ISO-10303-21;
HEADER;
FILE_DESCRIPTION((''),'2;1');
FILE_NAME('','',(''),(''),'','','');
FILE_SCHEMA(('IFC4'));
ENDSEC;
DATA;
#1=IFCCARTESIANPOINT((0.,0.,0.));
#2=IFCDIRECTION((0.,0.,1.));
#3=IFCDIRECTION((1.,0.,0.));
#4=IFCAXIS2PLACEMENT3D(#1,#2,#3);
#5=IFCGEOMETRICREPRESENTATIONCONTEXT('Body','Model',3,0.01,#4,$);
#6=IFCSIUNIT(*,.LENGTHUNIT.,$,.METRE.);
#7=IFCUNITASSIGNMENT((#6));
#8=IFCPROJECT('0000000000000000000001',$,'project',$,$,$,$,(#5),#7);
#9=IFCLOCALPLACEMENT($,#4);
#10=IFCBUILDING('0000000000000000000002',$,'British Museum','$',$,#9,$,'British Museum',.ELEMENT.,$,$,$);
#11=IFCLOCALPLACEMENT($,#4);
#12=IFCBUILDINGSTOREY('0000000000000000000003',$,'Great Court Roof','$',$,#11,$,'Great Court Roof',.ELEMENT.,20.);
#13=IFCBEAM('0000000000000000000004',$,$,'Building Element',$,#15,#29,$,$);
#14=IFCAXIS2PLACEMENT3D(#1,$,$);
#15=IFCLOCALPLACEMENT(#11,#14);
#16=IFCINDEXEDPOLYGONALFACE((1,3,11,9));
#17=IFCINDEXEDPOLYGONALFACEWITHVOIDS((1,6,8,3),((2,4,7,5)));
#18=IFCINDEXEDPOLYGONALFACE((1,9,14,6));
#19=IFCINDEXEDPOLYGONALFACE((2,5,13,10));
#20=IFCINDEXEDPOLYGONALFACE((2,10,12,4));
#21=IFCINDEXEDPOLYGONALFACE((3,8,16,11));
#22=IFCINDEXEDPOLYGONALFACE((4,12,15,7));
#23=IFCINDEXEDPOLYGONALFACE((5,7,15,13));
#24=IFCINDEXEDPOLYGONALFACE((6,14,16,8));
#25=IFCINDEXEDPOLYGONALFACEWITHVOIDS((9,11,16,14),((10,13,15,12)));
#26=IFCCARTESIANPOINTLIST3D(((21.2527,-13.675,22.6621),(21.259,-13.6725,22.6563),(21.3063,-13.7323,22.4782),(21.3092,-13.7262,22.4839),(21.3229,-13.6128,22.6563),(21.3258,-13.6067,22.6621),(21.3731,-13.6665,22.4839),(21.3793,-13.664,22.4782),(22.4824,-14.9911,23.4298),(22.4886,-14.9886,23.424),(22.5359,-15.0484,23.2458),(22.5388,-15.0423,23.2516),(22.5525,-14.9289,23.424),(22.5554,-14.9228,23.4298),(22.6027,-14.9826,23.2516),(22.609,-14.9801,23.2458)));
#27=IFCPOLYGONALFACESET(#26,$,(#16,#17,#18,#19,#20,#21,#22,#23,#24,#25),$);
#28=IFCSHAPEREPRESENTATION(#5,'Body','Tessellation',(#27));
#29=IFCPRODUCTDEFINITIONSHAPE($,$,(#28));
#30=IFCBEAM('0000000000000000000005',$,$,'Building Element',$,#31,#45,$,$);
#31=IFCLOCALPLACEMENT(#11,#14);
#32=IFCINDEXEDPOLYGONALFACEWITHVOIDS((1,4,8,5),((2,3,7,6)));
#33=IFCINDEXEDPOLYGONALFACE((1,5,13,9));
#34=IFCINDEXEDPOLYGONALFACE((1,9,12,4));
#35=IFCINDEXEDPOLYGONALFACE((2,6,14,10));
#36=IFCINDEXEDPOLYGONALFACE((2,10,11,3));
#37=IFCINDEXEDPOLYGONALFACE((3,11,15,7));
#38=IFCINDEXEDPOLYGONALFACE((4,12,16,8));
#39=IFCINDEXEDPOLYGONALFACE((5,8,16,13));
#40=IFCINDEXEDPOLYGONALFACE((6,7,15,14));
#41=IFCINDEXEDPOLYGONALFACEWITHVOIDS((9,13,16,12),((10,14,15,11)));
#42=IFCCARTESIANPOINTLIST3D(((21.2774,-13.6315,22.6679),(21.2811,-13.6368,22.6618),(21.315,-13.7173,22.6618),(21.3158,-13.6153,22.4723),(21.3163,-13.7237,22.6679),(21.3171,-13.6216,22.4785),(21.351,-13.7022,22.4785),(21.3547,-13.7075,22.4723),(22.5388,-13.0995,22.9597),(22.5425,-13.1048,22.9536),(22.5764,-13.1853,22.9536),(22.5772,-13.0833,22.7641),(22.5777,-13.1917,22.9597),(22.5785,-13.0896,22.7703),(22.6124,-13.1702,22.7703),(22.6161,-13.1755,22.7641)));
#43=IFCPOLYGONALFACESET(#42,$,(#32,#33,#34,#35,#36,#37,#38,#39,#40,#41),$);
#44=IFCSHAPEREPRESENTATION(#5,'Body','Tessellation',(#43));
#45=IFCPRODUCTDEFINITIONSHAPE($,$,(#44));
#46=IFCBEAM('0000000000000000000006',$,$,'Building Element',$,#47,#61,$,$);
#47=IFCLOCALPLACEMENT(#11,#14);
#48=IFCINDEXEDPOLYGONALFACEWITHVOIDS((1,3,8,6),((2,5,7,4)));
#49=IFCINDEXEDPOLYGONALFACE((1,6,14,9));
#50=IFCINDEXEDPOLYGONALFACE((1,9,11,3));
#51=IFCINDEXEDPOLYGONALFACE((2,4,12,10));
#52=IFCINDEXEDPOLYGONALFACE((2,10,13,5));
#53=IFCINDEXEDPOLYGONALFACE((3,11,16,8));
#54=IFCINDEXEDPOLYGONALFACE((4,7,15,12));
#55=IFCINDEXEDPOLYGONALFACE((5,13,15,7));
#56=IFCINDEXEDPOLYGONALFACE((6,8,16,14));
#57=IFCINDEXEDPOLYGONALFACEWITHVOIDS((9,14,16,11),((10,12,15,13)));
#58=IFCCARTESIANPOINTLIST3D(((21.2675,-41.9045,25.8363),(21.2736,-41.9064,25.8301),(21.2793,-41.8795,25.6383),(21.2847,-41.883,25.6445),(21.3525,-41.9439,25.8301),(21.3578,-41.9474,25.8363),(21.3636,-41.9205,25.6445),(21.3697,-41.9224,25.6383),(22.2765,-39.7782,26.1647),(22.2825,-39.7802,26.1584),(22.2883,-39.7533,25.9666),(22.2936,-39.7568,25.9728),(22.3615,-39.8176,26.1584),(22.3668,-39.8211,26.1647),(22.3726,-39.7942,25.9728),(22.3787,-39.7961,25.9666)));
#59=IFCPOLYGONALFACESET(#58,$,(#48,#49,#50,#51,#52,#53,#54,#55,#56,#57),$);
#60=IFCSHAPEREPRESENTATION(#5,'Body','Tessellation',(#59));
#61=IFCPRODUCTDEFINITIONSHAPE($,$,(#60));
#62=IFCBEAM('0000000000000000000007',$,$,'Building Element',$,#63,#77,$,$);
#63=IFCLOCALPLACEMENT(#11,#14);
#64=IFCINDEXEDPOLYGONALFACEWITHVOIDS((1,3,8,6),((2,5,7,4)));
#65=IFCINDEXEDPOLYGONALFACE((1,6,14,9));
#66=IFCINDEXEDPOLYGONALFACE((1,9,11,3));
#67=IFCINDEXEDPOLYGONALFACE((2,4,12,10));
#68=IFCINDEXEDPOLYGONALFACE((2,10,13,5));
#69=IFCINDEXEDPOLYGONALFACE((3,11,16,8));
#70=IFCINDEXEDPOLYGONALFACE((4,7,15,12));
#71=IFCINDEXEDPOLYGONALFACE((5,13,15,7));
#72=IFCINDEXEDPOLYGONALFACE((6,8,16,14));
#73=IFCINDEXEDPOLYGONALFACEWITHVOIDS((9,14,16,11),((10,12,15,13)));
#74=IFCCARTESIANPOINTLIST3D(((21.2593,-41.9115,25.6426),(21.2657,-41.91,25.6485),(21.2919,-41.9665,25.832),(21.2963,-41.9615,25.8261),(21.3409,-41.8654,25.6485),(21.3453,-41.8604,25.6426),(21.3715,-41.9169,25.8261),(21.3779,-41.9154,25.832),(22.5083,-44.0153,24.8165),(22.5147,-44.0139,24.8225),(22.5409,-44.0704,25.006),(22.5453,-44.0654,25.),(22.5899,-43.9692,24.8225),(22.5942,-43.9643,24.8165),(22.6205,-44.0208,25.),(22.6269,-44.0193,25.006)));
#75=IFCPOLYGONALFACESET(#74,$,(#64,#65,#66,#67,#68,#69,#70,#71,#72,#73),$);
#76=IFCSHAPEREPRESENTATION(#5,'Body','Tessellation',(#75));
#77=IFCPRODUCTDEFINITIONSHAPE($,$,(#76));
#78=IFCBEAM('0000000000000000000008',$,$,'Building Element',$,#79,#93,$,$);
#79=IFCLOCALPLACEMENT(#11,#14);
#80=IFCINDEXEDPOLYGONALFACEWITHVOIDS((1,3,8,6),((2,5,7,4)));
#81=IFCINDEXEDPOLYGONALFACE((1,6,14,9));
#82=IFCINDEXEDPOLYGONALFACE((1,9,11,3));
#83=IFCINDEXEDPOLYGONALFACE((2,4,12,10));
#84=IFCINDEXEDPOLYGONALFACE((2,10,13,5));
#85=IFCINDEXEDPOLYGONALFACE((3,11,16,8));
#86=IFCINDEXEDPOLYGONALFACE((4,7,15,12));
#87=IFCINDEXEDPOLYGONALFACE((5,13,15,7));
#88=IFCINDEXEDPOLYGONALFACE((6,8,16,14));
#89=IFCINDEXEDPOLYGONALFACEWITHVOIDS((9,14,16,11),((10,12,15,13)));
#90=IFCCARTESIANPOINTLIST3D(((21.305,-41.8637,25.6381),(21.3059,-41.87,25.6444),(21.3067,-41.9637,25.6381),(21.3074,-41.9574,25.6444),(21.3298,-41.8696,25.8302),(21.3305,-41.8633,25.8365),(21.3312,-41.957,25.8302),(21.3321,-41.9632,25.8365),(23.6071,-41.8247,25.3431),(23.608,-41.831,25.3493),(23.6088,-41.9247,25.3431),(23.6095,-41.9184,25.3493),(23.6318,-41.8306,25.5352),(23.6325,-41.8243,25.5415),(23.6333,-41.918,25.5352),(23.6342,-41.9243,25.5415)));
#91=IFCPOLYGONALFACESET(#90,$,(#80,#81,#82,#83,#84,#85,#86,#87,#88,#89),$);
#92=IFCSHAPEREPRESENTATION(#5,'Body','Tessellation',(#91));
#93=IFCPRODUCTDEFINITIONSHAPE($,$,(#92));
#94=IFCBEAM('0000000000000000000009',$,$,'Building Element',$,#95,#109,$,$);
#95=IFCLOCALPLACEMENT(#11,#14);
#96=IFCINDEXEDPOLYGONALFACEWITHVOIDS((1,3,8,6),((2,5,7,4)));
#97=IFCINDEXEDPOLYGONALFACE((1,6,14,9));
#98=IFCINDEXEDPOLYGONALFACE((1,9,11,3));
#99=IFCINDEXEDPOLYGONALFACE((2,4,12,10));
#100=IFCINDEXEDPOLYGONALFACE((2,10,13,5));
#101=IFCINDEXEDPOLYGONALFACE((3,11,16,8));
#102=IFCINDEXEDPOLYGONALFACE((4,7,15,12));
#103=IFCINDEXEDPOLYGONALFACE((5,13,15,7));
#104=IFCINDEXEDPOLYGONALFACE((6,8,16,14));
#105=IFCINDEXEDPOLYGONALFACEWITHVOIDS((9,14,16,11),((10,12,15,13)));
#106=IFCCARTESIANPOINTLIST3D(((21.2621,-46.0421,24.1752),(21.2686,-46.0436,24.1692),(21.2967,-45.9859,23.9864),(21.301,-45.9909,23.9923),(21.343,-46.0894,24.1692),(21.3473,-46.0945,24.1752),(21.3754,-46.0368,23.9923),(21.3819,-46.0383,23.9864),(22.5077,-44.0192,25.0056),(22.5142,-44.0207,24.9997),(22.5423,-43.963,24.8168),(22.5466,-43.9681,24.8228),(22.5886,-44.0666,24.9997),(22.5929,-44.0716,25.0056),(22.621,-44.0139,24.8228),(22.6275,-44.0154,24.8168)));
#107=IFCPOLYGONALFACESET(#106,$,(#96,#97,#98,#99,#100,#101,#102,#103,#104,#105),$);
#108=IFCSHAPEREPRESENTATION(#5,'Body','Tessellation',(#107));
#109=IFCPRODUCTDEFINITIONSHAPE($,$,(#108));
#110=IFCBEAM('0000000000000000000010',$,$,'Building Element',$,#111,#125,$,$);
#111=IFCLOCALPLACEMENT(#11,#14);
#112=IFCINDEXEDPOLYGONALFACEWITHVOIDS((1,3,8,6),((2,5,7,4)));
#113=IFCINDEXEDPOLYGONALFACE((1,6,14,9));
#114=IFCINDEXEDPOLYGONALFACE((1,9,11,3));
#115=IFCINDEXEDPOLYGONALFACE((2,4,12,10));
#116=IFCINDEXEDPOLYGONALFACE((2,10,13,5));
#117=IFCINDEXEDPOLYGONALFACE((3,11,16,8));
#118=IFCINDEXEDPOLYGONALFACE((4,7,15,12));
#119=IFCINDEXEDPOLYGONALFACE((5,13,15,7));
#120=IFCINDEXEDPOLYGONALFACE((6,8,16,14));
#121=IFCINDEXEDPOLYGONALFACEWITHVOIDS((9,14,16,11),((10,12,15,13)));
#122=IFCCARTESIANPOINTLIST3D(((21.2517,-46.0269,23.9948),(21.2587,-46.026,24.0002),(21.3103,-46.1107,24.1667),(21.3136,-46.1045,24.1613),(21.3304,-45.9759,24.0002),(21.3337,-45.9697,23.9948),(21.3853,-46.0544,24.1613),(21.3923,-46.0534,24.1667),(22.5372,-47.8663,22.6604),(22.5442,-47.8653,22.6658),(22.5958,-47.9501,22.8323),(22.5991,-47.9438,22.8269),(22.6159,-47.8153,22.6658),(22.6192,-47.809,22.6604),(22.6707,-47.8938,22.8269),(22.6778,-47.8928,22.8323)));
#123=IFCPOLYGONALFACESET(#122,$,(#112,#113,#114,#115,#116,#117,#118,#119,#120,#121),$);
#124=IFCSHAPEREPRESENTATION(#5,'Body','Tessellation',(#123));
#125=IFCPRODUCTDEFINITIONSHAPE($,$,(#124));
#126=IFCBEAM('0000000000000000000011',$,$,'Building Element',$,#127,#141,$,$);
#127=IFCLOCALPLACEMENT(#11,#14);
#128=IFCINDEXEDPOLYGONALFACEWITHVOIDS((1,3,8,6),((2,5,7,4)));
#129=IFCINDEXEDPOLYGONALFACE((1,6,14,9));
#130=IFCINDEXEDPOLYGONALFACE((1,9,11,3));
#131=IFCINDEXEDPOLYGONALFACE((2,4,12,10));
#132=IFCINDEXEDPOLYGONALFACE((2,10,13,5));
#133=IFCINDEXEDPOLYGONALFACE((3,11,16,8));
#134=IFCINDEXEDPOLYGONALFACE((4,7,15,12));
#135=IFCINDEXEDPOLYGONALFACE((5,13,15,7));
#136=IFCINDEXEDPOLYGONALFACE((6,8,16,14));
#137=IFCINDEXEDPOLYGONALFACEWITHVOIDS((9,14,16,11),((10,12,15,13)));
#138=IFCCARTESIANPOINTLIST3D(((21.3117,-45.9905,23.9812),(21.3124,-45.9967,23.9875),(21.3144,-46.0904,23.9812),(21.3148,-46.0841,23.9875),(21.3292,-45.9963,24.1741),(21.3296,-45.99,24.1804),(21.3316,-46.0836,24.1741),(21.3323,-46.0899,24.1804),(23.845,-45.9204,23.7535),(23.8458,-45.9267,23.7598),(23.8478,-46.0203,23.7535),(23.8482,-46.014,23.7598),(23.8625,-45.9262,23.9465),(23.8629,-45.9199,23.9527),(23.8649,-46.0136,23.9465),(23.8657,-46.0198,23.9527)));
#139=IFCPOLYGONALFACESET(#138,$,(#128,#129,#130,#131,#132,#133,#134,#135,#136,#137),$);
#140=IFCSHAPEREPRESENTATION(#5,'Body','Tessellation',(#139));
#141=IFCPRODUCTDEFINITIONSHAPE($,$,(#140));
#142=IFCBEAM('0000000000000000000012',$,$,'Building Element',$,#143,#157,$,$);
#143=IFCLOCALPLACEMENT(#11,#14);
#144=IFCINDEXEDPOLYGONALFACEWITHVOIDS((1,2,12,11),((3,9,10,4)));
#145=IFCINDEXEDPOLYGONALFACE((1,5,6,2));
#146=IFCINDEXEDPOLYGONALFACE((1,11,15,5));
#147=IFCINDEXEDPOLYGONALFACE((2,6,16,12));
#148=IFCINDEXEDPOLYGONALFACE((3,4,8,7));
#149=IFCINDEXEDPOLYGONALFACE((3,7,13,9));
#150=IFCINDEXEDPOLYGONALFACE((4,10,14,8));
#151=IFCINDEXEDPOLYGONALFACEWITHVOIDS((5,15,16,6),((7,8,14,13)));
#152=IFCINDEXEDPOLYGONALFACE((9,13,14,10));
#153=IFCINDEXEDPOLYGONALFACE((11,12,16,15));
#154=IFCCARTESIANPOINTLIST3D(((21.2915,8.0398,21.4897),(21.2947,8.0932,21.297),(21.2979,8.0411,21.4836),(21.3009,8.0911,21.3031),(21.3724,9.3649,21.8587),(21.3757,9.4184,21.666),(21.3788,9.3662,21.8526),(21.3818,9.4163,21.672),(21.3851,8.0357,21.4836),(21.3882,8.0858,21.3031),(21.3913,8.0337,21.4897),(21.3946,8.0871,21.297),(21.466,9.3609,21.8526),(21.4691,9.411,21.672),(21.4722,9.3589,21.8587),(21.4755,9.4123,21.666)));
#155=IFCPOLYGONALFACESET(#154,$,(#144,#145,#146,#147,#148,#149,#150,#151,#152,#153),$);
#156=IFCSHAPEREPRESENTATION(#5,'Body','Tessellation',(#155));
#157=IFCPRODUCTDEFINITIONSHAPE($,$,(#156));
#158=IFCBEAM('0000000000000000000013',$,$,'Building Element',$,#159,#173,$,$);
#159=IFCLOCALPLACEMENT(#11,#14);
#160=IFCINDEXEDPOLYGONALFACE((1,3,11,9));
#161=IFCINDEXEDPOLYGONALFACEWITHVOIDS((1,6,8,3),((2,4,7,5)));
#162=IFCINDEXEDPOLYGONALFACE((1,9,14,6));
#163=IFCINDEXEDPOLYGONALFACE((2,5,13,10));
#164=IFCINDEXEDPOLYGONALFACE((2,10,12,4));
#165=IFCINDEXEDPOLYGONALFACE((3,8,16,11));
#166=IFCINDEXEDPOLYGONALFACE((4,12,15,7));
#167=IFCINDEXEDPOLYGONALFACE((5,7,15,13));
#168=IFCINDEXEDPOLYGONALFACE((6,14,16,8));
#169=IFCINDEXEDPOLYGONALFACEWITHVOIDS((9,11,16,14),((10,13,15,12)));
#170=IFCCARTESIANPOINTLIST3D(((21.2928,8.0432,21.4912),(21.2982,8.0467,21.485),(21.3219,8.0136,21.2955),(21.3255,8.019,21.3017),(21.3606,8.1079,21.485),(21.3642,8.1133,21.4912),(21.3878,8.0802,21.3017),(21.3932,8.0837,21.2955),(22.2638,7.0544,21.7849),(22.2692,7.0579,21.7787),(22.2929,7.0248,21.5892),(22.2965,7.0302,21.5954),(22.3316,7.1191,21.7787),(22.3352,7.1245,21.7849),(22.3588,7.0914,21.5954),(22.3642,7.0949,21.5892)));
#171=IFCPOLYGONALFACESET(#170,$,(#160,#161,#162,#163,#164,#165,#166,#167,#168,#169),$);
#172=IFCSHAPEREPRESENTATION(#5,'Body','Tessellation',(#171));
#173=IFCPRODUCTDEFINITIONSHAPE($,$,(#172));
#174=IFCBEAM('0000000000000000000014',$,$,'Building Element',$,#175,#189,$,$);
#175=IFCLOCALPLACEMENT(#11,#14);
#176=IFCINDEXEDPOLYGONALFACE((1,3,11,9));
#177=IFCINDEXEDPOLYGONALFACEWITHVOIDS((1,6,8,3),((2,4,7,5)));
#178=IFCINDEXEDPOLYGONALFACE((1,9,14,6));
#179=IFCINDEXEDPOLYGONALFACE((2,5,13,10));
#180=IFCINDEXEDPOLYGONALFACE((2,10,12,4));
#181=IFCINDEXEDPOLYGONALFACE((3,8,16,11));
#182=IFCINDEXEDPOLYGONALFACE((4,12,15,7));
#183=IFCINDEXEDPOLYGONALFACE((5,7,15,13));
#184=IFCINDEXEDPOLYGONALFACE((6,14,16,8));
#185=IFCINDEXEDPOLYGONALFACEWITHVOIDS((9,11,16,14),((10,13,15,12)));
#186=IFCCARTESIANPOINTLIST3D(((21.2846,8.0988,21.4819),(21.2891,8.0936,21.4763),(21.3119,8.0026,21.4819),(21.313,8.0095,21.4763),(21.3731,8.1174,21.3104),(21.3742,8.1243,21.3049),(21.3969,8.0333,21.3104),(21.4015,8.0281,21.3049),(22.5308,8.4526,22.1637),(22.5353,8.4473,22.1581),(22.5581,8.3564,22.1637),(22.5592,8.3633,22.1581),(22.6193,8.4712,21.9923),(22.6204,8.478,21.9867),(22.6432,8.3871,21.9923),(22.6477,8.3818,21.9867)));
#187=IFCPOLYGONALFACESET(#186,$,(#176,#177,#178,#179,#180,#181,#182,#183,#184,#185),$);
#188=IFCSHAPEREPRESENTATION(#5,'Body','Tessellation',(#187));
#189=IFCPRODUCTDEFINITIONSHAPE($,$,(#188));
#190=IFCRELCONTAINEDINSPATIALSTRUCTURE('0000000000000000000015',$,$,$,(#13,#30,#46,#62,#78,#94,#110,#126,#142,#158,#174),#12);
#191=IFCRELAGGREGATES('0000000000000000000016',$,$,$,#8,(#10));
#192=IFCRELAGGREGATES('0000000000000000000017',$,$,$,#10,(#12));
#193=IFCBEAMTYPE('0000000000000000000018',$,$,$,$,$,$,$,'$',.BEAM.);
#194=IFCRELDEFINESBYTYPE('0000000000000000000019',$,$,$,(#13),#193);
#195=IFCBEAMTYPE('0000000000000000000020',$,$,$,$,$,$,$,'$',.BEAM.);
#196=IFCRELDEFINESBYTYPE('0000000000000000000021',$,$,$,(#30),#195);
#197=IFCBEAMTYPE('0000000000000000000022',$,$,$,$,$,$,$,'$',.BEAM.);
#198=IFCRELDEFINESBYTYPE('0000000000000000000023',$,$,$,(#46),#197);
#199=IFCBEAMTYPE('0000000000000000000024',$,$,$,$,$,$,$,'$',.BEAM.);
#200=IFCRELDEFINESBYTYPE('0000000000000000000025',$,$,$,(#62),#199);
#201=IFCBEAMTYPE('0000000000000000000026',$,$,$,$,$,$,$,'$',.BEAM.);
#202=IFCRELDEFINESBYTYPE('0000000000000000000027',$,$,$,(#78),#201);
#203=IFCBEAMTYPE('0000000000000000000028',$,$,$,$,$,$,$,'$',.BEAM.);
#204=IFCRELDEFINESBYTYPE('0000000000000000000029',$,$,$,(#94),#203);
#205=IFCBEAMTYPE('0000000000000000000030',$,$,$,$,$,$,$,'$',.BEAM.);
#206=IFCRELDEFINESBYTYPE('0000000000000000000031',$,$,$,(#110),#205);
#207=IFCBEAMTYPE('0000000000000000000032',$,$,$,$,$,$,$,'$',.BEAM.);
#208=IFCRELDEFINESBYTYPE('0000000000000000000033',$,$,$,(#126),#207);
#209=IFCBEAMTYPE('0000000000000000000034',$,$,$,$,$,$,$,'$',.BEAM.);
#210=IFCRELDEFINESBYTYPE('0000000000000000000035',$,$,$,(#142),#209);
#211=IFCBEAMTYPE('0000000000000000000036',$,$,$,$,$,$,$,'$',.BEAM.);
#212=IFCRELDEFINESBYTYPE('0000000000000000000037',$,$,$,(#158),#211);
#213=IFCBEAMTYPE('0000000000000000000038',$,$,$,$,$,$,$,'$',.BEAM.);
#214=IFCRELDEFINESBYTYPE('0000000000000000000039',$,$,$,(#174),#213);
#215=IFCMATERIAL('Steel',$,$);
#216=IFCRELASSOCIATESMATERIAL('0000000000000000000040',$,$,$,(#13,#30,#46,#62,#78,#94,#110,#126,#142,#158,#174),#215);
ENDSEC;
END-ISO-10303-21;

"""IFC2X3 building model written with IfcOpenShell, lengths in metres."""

from ifc_helpers import new_model, si_unit, frame, origin_with_axes, origin_2d, place, context, project, spatial, hollow_rectangle, extrude, material, type_object, element, save


model = new_model("IFC2X3")

# Units and contexts
model_context = context("Model", 3, precision=0.01, world=origin_with_axes(), identifier="Body")
ifc_project = project(units=[si_unit("LENGTHUNIT", "METRE")], contexts=[model_context])

# Building, storey
building_placement = place(None, origin_with_axes())
building = spatial("IfcBuilding", under=ifc_project, at=building_placement, Name="British Museum", Description="$", LongName="British Museum", CompositionType="ELEMENT")
storey_placement = place(None, origin_with_axes())
storey = spatial("IfcBuildingStorey", under=building, at=storey_placement, Name="Great Court Roof", Description="$", LongName="Great Court Roof", CompositionType="ELEMENT", Elevation=20.0)

# Beams
ifc_material = material(Name="Steel")
beam_type_1 = type_object("IfcBeamType", ElementType="$", PredefinedType="BEAM")
beam_1_placement = place(None, origin_with_axes())
element("IfcBeam", 1, at=beam_1_placement, inside=storey, type_object=beam_type_1, material=ifc_material, Description="Building Element", context=model_context, shape_type="SweptSolid", body=[
    extrude(hollow_rectangle(XDim=0.1, YDim=0.2, WallThickness=0.0063, InnerFilletRadius=0.0, OuterFilletRadius=0.0, at=origin_2d()), frame((21.316, -13.6695, 22.5701), z_axis=(0.628033, -0.672197, 0.392079), x_axis=(0.730703, 0.682695, 0.0)), (0.0, 0.0, 1.0), 1.9579),
])
beam_type_2 = type_object("IfcBeamType", ElementType="$", PredefinedType="BEAM")
beam_2_placement = place(None, origin_with_axes())
element("IfcBeam", 2, at=beam_2_placement, inside=storey, type_object=beam_type_2, material=ifc_material, Description="Building Element", context=model_context, shape_type="SweptSolid", body=[
    extrude(hollow_rectangle(XDim=0.1, YDim=0.2, WallThickness=0.0063, InnerFilletRadius=0.0, OuterFilletRadius=0.0, at=origin_2d()), frame((21.316, -13.6695, 22.5701), z_axis=(0.90116, 0.380072, 0.208459), x_axis=(-0.388609, 0.921403, 0.0)), (0.0, 0.0, 1.0), 1.3998),
])
beam_type_3 = type_object("IfcBeamType", ElementType="$", PredefinedType="BEAM")
beam_3_placement = place(None, origin_with_axes())
element("IfcBeam", 3, at=beam_3_placement, inside=storey, type_object=beam_type_3, material=ifc_material, Description="Building Element", context=model_context, shape_type="SweptSolid", body=[
    extrude(hollow_rectangle(XDim=0.1, YDim=0.2, WallThickness=0.0063, InnerFilletRadius=0.0, OuterFilletRadius=0.0, at=origin_2d()), frame((21.3186, -41.9135, 25.7373), z_axis=(0.424592, 0.894779, 0.138174), x_axis=(-0.903445, 0.428704, 0.0)), (0.0, 0.0, 1.0), 2.3763),
])
beam_type_4 = type_object("IfcBeamType", ElementType="$", PredefinedType="BEAM")
beam_4_placement = place(None, origin_with_axes())
element("IfcBeam", 4, at=beam_4_placement, inside=storey, type_object=beam_type_4, material=ifc_material, Description="Building Element", context=model_context, shape_type="SweptSolid", body=[
    extrude(hollow_rectangle(XDim=0.1, YDim=0.2, WallThickness=0.0063, InnerFilletRadius=0.0, OuterFilletRadius=0.0, at=origin_2d()), frame((21.3186, -41.9135, 25.7373), z_axis=(0.483662, -0.814704, -0.319888), x_axis=(0.859886, 0.510486, 0.0)), (0.0, 0.0, 1.0), 2.5824),
])
beam_type_5 = type_object("IfcBeamType", ElementType="$", PredefinedType="BEAM")
beam_5_placement = place(None, origin_with_axes())
element("IfcBeam", 5, at=beam_5_placement, inside=storey, type_object=beam_type_5, material=ifc_material, Description="Building Element", context=model_context, shape_type="SweptSolid", body=[
    extrude(hollow_rectangle(XDim=0.1, YDim=0.2, WallThickness=0.0063, InnerFilletRadius=0.0, OuterFilletRadius=0.0, at=origin_2d()), frame((21.3186, -41.9135, 25.7373), z_axis=(0.991748, 0.016784, -0.127103), x_axis=(-0.016921, 0.999857, 0.0)), (0.0, 0.0, 1.0), 2.3212),
])
beam_type_6 = type_object("IfcBeamType", ElementType="$", PredefinedType="BEAM")
beam_6_placement = place(None, origin_with_axes())
element("IfcBeam", 6, at=beam_6_placement, inside=storey, type_object=beam_type_6, material=ifc_material, Description="Building Element", context=model_context, shape_type="SweptSolid", body=[
    extrude(hollow_rectangle(XDim=0.1, YDim=0.2, WallThickness=0.0063, InnerFilletRadius=0.0, OuterFilletRadius=0.0, at=origin_2d()), frame((21.322, -46.0402, 24.0808), z_axis=(0.494955, 0.803819, 0.329993), x_axis=(-0.851518, 0.524326, 0.0)), (0.0, 0.0, 1.0), 2.5166),
])
beam_type_7 = type_object("IfcBeamType", ElementType="$", PredefinedType="BEAM")
beam_7_placement = place(None, origin_with_axes())
element("IfcBeam", 7, at=beam_7_placement, inside=storey, type_object=beam_type_7, material=ifc_material, Description="Building Element", context=model_context, shape_type="SweptSolid", body=[
    extrude(hollow_rectangle(XDim=0.1, YDim=0.2, WallThickness=0.0063, InnerFilletRadius=0.0, OuterFilletRadius=0.0, at=origin_2d()), frame((21.322, -46.0402, 24.0808), z_axis=(0.49237, -0.704509, -0.511116), x_axis=(0.819662, 0.572848, 0.0)), (0.0, 0.0, 1.0), 2.6108),
])
beam_type_8 = type_object("IfcBeamType", ElementType="$", PredefinedType="BEAM")
beam_8_placement = place(None, origin_with_axes())
element("IfcBeam", 8, at=beam_8_placement, inside=storey, type_object=beam_type_8, material=ifc_material, Description="Building Element", context=model_context, shape_type="SweptSolid", body=[
    extrude(hollow_rectangle(XDim=0.1, YDim=0.2, WallThickness=0.0063, InnerFilletRadius=0.0, OuterFilletRadius=0.0, at=origin_2d()), frame((21.322, -46.0402, 24.0808), z_axis=(0.99561, 0.027538, -0.08946), x_axis=(-0.027649, 0.999618, 0.0)), (0.0, 0.0, 1.0), 2.5445),
])
beam_type_9 = type_object("IfcBeamType", ElementType="$", PredefinedType="BEAM")
beam_9_placement = place(None, origin_with_axes())
element("IfcBeam", 9, at=beam_9_placement, inside=storey, type_object=beam_type_9, material=ifc_material, Description="Building Element", context=model_context, shape_type="SweptSolid", body=[
    extrude(hollow_rectangle(XDim=0.1, YDim=0.2, WallThickness=0.0063, InnerFilletRadius=0.0, OuterFilletRadius=0.0, at=origin_2d()), frame((21.343, 8.0634, 21.3934), z_axis=(0.058717, 0.961699, 0.267744), x_axis=(-0.998141, 0.060942, 0.0)), (0.0, 0.0, 1.0), 1.378),
])
beam_type_10 = type_object("IfcBeamType", ElementType="$", PredefinedType="BEAM")
beam_10_placement = place(None, origin_with_axes())
element("IfcBeam", 10, at=beam_10_placement, inside=storey, type_object=beam_type_10, material=ifc_material, Description="Building Element", context=model_context, shape_type="SweptSolid", body=[
    extrude(hollow_rectangle(XDim=0.1, YDim=0.2, WallThickness=0.0063, InnerFilletRadius=0.0, OuterFilletRadius=0.0, at=origin_2d()), frame((21.343, 8.0634, 21.3934), z_axis=(0.685436, -0.697998, 0.207305), x_axis=(0.713498, 0.700657, 0.0)), (0.0, 0.0, 1.0), 1.4166),
])
beam_type_11 = type_object("IfcBeamType", ElementType="$", PredefinedType="BEAM")
beam_11_placement = place(None, origin_with_axes())
element("IfcBeam", 11, at=beam_11_placement, inside=storey, type_object=beam_type_11, material=ifc_material, Description="Building Element", context=model_context, shape_type="SweptSolid", body=[
    extrude(hollow_rectangle(XDim=0.1, YDim=0.2, WallThickness=0.0063, InnerFilletRadius=0.0, OuterFilletRadius=0.0, at=origin_2d()), frame((21.343, 8.0634, 21.3934), z_axis=(0.851279, 0.241657, 0.465753), x_axis=(-0.273085, 0.96199, 0.0)), (0.0, 0.0, 1.0), 1.464),
])

save(model, "model.ifc")
